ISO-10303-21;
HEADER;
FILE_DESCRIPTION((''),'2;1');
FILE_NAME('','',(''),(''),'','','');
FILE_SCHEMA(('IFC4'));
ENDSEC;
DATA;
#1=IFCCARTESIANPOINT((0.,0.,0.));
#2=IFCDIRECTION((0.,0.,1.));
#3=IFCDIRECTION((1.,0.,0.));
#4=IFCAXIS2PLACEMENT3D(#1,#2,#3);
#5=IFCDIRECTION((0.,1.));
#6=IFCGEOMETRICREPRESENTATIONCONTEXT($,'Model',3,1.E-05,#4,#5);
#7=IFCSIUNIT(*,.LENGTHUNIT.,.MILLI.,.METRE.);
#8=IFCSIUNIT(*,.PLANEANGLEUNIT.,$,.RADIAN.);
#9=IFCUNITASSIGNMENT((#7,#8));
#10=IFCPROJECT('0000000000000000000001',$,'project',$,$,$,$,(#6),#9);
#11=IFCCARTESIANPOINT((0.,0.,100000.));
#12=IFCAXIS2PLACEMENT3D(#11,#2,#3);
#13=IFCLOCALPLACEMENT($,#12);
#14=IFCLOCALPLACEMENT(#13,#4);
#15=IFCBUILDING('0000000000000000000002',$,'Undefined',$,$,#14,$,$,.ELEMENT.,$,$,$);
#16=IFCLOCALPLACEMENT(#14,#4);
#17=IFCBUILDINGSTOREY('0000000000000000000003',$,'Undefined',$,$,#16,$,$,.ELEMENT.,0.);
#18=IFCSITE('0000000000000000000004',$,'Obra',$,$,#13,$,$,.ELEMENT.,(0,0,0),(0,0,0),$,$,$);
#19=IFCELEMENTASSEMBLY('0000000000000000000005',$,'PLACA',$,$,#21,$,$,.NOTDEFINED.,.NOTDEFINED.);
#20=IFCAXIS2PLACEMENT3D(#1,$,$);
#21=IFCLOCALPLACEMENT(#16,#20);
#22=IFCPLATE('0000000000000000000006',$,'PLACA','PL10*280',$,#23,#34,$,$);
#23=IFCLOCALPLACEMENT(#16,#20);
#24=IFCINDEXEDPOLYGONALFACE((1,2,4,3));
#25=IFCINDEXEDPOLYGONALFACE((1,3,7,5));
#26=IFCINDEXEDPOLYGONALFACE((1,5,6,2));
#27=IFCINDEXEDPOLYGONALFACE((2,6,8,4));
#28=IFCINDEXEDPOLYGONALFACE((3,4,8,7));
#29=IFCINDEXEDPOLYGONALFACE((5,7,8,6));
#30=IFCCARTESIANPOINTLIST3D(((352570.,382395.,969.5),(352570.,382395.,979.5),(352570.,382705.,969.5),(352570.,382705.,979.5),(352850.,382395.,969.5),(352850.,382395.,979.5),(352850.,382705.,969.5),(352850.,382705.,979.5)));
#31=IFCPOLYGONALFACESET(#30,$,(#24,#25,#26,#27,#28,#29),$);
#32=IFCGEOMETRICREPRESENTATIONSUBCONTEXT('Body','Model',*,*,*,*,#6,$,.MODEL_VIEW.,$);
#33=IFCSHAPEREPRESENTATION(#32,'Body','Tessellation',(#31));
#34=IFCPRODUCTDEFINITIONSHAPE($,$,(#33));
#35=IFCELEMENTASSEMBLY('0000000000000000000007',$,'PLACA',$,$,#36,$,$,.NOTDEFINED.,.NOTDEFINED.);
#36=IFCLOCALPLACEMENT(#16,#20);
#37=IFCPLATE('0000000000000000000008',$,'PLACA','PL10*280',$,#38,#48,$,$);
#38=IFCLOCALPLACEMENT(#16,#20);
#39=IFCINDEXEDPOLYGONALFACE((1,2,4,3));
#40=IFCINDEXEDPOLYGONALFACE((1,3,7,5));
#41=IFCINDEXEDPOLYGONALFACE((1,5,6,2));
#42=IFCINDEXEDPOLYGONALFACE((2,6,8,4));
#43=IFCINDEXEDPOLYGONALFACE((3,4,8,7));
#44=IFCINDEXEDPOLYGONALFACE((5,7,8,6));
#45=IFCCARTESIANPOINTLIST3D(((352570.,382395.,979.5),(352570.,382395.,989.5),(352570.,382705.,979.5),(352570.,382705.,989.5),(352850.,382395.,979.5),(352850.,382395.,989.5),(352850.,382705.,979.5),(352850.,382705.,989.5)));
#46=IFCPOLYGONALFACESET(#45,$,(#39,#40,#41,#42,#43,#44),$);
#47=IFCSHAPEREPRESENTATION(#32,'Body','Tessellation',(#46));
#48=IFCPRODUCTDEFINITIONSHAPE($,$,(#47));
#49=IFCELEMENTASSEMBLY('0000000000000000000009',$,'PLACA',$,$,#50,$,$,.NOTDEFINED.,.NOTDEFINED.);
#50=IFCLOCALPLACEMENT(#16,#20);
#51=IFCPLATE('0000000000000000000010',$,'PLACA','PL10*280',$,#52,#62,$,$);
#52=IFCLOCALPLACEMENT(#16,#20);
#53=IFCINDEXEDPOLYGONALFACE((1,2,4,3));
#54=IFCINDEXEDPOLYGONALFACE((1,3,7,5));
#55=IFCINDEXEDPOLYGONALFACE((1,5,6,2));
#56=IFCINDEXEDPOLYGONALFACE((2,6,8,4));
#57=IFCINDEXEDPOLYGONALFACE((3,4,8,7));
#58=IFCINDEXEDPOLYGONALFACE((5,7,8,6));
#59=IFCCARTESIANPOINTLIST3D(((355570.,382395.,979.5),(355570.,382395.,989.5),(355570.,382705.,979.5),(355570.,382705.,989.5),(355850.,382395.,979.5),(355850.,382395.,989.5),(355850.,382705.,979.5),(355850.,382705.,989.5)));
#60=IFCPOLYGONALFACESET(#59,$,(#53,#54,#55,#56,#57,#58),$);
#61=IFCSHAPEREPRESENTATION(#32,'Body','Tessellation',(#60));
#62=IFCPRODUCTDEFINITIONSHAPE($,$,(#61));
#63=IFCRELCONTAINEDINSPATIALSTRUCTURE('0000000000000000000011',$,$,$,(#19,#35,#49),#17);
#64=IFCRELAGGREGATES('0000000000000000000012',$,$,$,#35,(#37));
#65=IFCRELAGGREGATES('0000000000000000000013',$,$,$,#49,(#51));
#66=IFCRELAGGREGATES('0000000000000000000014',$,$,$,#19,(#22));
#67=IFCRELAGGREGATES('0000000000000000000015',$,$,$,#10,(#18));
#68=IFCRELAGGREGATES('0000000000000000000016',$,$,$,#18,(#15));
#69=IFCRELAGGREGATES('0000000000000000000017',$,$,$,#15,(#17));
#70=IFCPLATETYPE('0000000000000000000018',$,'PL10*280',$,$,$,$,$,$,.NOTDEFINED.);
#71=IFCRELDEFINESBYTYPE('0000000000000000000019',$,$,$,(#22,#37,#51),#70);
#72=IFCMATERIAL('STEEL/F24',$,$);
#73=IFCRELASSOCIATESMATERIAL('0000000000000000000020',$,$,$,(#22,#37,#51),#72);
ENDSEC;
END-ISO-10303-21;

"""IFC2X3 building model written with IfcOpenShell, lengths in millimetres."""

from ifc_helpers import new_model, si_unit, direction, frame, origin_with_axes, place, context, subcontext, project, spatial, polyline, outline, extrude, material, type_object, element, aggregate, save


model = new_model("IFC2X3")

# Units and contexts
model_context = context("Model", 3, precision=1e-05, world=origin_with_axes(), true_north=direction((0.0, 1.0)))
body_context = subcontext(model_context, "Body", "Model", "MODEL_VIEW")
ifc_project = project(units=[si_unit("LENGTHUNIT", "METRE", prefix="MILLI"), si_unit("PLANEANGLEUNIT", "RADIAN")], contexts=[model_context])

# Site, building, storey
site_placement = place(None, frame((0.0, 0.0, 100000.0), z_axis=(0.0, 0.0, 1.0), x_axis=(1.0, 0.0, 0.0)))
site = spatial("IfcSite", under=ifc_project, at=site_placement, Name="Obra", CompositionType="ELEMENT", RefLatitude=(0, 0, 0), RefLongitude=(0, 0, 0))
building_placement = place(site_placement, origin_with_axes())
building = spatial("IfcBuilding", under=site, at=building_placement, Name="Undefined", CompositionType="ELEMENT")
storey_placement = place(building_placement, origin_with_axes())
storey = spatial("IfcBuildingStorey", under=building, at=storey_placement, Name="Undefined", CompositionType="ELEMENT", Elevation=0.0)

# Shared definitions
ifc_material_1 = material(Name="STEEL/F24")

# Element assemblies, plates
plate_type_1 = type_object("IfcPlateType", Name="PL10*280", PredefinedType="NOTDEFINED")
assembly_1_placement = place(storey_placement, origin_with_axes())
assembly_1 = element("IfcElementAssembly", 1, at=assembly_1_placement, inside=storey, Name="PLACA", AssemblyPlace="NOTDEFINED", PredefinedType="NOTDEFINED")
plate_1_placement = place(assembly_1_placement, frame((352570.0, 382395.0, 974.5), z_axis=(0.0, 0.0, 1.0), x_axis=(1.0, 0.0, 0.0)))
plate_1 = element("IfcPlate", 2, at=plate_1_placement, type_object=plate_type_1, material=ifc_material_1, Name="PLACA", Description="PL10*280", context=body_context, shape_type="SweptSolid", body=[
    extrude(outline(polyline([(0.0, 0.0), (280.0, 0.0), (280.0, 310.0), (0.0, 310.0), (0.0, 0.0)])), frame((0.0, 0.0, -5.0), z_axis=(0.0, 0.0, 1.0), x_axis=(1.0, 0.0, 0.0)), (0.0, 0.0, 1.0), 10.0),
])
assembly_2_placement = place(storey_placement, origin_with_axes())
assembly_2 = element("IfcElementAssembly", 3, at=assembly_2_placement, inside=storey, Name="PLACA", AssemblyPlace="NOTDEFINED", PredefinedType="NOTDEFINED")
plate_2_placement = place(assembly_2_placement, frame((352570.0, 382395.0, 984.5), z_axis=(0.0, 0.0, 1.0), x_axis=(1.0, 0.0, 0.0)))
plate_2 = element("IfcPlate", 4, at=plate_2_placement, type_object=plate_type_1, material=ifc_material_1, Name="PLACA", Description="PL10*280", context=body_context, shape_type="SweptSolid", body=[
    extrude(outline(polyline([(0.0, 0.0), (280.0, 0.0), (280.0, 310.0), (0.0, 310.0), (0.0, 0.0)])), frame((0.0, 0.0, -5.0), z_axis=(0.0, 0.0, 1.0), x_axis=(1.0, 0.0, 0.0)), (0.0, 0.0, 1.0), 10.0),
])
aggregate(assembly_2, [plate_2])
assembly_3_placement = place(storey_placement, origin_with_axes())
assembly_3 = element("IfcElementAssembly", 5, at=assembly_3_placement, inside=storey, Name="PLACA", AssemblyPlace="NOTDEFINED", PredefinedType="NOTDEFINED")
plate_3_placement = place(assembly_3_placement, frame((355570.0, 382395.0, 984.5), z_axis=(0.0, 0.0, 1.0), x_axis=(1.0, 0.0, 0.0)))
plate_3 = element("IfcPlate", 6, at=plate_3_placement, type_object=plate_type_1, material=ifc_material_1, Name="PLACA", Description="PL10*280", context=body_context, shape_type="SweptSolid", body=[
    extrude(outline(polyline([(0.0, 0.0), (280.0, 0.0), (280.0, 310.0), (0.0, 310.0), (0.0, 0.0)])), frame((0.0, 0.0, -5.0), z_axis=(0.0, 0.0, 1.0), x_axis=(1.0, 0.0, 0.0)), (0.0, 0.0, 1.0), 10.0),
])
aggregate(assembly_3, [plate_3])

aggregate(assembly_1, [plate_1])

save(model, "model.ifc")
